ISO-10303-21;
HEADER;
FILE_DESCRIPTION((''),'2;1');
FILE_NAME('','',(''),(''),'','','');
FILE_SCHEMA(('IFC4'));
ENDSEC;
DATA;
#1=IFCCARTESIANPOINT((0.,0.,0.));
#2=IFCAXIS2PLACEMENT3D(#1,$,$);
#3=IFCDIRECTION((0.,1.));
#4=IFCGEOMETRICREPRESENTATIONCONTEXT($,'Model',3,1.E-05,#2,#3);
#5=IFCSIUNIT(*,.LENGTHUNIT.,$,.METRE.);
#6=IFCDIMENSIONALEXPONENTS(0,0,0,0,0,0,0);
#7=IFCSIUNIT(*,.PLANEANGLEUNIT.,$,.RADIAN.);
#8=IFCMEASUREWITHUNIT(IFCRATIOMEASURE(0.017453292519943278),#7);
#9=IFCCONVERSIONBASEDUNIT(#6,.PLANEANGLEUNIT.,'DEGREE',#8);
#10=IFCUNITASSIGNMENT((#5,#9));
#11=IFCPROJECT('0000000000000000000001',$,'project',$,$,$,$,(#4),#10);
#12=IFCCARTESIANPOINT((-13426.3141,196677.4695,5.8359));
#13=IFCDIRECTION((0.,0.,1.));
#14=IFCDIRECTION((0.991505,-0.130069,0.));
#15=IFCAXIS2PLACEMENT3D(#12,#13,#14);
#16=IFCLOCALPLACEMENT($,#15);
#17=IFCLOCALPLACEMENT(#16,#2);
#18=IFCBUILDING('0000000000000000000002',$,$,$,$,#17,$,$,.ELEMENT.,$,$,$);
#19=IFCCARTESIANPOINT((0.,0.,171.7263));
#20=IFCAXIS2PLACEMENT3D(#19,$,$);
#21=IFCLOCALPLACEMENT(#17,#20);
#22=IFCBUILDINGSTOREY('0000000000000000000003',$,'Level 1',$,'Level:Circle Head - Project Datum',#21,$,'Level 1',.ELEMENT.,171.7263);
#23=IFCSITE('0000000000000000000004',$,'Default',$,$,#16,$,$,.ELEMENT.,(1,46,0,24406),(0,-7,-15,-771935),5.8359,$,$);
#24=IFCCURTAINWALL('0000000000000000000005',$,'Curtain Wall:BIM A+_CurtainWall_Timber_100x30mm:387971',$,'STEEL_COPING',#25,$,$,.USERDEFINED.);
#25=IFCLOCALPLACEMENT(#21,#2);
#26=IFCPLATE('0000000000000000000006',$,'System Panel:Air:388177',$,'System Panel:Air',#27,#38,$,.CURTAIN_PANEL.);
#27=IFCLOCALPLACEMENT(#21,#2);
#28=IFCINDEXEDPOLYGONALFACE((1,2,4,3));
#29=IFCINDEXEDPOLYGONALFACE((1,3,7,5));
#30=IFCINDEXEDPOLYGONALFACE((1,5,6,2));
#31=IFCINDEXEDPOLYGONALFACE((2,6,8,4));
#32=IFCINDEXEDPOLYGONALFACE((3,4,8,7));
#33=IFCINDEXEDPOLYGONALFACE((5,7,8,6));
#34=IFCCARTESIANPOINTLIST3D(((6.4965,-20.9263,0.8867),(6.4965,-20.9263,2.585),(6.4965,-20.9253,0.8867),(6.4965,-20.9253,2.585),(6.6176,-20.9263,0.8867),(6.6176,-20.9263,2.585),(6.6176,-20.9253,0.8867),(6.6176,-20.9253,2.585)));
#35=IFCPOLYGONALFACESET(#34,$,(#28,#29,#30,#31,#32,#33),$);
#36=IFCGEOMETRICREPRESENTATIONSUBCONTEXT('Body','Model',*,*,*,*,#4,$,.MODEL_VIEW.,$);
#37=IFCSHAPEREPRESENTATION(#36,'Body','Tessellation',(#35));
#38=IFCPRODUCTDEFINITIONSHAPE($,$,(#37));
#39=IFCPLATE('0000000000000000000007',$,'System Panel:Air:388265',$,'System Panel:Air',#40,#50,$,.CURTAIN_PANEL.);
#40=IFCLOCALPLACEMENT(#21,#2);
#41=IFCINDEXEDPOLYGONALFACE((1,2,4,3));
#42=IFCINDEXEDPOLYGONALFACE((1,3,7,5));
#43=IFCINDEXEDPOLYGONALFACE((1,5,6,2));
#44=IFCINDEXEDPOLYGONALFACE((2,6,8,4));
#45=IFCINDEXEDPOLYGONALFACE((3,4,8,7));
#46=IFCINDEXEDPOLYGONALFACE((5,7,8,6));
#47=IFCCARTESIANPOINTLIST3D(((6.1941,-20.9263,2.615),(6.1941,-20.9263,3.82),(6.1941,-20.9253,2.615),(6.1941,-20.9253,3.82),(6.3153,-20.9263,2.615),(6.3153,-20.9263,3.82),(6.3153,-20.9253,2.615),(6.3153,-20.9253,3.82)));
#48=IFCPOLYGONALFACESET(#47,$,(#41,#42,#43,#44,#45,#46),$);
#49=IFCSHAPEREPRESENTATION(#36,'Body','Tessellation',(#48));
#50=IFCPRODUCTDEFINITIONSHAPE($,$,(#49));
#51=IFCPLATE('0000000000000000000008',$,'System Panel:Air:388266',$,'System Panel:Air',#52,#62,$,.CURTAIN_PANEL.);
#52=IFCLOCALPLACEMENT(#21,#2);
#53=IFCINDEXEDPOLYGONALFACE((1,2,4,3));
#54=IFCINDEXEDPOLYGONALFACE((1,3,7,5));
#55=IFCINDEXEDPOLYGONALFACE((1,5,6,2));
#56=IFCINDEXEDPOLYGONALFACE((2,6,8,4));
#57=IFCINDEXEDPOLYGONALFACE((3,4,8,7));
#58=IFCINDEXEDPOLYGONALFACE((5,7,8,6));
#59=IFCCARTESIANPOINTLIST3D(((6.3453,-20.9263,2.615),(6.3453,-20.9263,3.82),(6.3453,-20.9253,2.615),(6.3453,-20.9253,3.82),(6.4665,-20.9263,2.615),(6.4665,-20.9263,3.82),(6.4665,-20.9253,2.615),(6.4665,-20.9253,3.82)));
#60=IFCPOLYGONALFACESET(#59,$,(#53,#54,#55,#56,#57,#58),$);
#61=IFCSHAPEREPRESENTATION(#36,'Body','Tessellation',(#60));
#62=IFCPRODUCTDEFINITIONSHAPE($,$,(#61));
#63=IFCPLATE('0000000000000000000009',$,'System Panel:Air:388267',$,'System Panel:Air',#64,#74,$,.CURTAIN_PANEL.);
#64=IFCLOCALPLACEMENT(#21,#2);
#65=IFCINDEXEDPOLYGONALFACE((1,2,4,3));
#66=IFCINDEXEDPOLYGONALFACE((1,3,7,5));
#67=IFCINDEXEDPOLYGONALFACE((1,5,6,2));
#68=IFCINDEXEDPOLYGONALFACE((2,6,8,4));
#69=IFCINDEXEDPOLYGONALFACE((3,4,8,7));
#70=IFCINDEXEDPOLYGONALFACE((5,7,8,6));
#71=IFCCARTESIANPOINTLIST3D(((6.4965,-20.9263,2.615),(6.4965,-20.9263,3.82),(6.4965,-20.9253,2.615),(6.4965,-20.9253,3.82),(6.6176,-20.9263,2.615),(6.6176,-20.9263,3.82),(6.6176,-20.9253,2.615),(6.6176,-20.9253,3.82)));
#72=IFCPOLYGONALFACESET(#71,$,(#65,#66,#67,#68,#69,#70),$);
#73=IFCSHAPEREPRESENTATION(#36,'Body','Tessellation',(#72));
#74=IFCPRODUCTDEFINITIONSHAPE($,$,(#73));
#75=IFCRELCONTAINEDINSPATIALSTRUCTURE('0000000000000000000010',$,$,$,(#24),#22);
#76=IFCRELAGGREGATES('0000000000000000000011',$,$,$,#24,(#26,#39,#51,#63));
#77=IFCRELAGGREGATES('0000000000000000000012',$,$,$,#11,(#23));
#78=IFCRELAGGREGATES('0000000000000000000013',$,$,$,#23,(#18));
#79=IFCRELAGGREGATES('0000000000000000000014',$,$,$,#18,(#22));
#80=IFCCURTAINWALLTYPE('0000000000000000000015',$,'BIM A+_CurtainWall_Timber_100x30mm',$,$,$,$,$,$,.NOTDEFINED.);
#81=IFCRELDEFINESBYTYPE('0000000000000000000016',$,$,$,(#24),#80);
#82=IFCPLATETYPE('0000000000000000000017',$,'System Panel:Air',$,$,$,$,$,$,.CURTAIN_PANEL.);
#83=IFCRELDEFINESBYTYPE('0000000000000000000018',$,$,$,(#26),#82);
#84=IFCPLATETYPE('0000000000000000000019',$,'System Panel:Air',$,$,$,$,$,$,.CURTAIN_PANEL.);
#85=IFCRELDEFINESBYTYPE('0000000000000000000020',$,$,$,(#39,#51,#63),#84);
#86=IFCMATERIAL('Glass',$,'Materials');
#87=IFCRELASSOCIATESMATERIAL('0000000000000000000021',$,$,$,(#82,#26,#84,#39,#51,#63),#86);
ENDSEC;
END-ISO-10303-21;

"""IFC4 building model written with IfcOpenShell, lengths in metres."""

from ifc_helpers import new_model, entity, si_unit, converted_unit, direction, frame, origin, place, context, subcontext, project, spatial, indexed_curve, outline, extrude, source, transform, mapped, material, type_object, type_shapes, element, aggregate, save


model = new_model("IFC4")

# Units and contexts
model_context = context("Model", 3, precision=1e-05, world=origin(), true_north=direction((0.0, 1.0)))
body_context = subcontext(model_context, "Body", "Model", "MODEL_VIEW")
ifc_project = project(units=[si_unit("LENGTHUNIT", "METRE"), converted_unit("PLANEANGLEUNIT", "DEGREE", entity("IfcRatioMeasure", 0.017453292519943278), si_unit("PLANEANGLEUNIT", "RADIAN"), dimensions=[0, 0, 0, 0, 0, 0, 0])], contexts=[model_context])

# Site, building, storey
site_placement = place(None, frame((-13426.3141, 196677.4695, 5.8359), z_axis=(0.0, 0.0, 1.0), x_axis=(0.991505, -0.130069, 0.0)))
site = spatial("IfcSite", under=ifc_project, at=site_placement, Name="Default", CompositionType="ELEMENT", RefLatitude=(1, 46, 0, 24406), RefLongitude=(0, -7, -15, -771935), RefElevation=5.8359)
building_placement = place(site_placement, origin())
building = spatial("IfcBuilding", under=site, at=building_placement, CompositionType="ELEMENT")
storey_placement = place(building_placement, frame((0.0, 0.0, 171.7263)))
storey = spatial("IfcBuildingStorey", under=building, at=storey_placement, Name="Level 1", ObjectType="Level:Circle Head - Project Datum", LongName="Level 1", CompositionType="ELEMENT", Elevation=171.7263)

# Curtain wall
curtain_wall_type_1 = type_object("IfcCurtainWallType", Name="BIM A+_CurtainWall_Timber_100x30mm", PredefinedType="NOTDEFINED")
curtain_wall_1_placement = place(storey_placement, frame((0.0, 0.0, -171.7263)))
curtain_wall_1 = element("IfcCurtainWall", 1, at=curtain_wall_1_placement, inside=storey, type_object=curtain_wall_type_1, Name="Curtain Wall:BIM A+_CurtainWall_Timber_100x30mm:387971", ObjectType="STEEL_COPING", PredefinedType="USERDEFINED")

# Plates
ifc_material_1 = material(Name="Glass", Category="Materials")
plate_type_1 = type_object("IfcPlateType", Name="System Panel:Air", PredefinedType="CURTAIN_PANEL", material=ifc_material_1)
shared_shape_1 = source(origin(), body_context, "Body", "SweptSolid", [
    extrude(outline(indexed_curve([(-0.0005, -0.0606), (0.0005, -0.0606), (0.0005, 0.0606), (-0.0005, 0.0606), (-0.0005, -0.0606)], self_intersect=False)), frame((0.0, 0.0, 0.0), z_axis=(0.0, 0.0, 1.0), x_axis=(0.0, 1.0, 0.0)), (0.0, 0.0, 1.0), 1.6983),
])
type_shapes(plate_type_1, [shared_shape_1])
plate_1_placement = place(curtain_wall_1_placement, frame((6.557, -20.9258, 172.613)))
plate_1 = element("IfcPlate", 2, at=plate_1_placement, type_object=plate_type_1, material=ifc_material_1, Name="System Panel:Air:388177", ObjectType="System Panel:Air", PredefinedType="CURTAIN_PANEL", context=body_context, shape_type="MappedRepresentation", body=[
    mapped(shared_shape_1, transform((0.0, 0.0, 0.0), scale=1.0)),
])
plate_type_2 = type_object("IfcPlateType", Name="System Panel:Air", PredefinedType="CURTAIN_PANEL", material=ifc_material_1)
shared_shape_2 = source(origin(), body_context, "Body", "SweptSolid", [
    extrude(outline(indexed_curve([(-0.0005, -0.0606), (0.0005, -0.0606), (0.0005, 0.0606), (-0.0005, 0.0606), (-0.0005, -0.0606)], self_intersect=False)), frame((0.0, 0.0, 0.0), z_axis=(0.0, 0.0, 1.0), x_axis=(0.0, 1.0, 0.0)), (0.0, 0.0, 1.0), 1.205),
])
type_shapes(plate_type_2, [shared_shape_2])
plate_2_placement = place(curtain_wall_1_placement, frame((6.2547, -20.9258, 174.3413)))
plate_2 = element("IfcPlate", 3, at=plate_2_placement, type_object=plate_type_2, material=ifc_material_1, Name="System Panel:Air:388265", ObjectType="System Panel:Air", PredefinedType="CURTAIN_PANEL", context=body_context, shape_type="MappedRepresentation", body=[
    mapped(shared_shape_2, transform((0.0, 0.0, 0.0), scale=1.0)),
])
plate_3_placement = place(curtain_wall_1_placement, frame((6.4059, -20.9258, 174.3413)))
plate_3 = element("IfcPlate", 4, at=plate_3_placement, type_object=plate_type_2, material=ifc_material_1, Name="System Panel:Air:388266", ObjectType="System Panel:Air", PredefinedType="CURTAIN_PANEL", context=body_context, shape_type="MappedRepresentation", body=[
    mapped(shared_shape_2, transform((0.0, 0.0, 0.0), scale=1.0)),
])
plate_4_placement = place(curtain_wall_1_placement, frame((6.557, -20.9258, 174.3413)))
plate_4 = element("IfcPlate", 5, at=plate_4_placement, type_object=plate_type_2, material=ifc_material_1, Name="System Panel:Air:388267", ObjectType="System Panel:Air", PredefinedType="CURTAIN_PANEL", context=body_context, shape_type="MappedRepresentation", body=[
    mapped(shared_shape_2, transform((0.0, 0.0, 0.0), scale=1.0)),
])
aggregate(curtain_wall_1, [plate_1, plate_2, plate_3, plate_4])

save(model, "model.ifc")
